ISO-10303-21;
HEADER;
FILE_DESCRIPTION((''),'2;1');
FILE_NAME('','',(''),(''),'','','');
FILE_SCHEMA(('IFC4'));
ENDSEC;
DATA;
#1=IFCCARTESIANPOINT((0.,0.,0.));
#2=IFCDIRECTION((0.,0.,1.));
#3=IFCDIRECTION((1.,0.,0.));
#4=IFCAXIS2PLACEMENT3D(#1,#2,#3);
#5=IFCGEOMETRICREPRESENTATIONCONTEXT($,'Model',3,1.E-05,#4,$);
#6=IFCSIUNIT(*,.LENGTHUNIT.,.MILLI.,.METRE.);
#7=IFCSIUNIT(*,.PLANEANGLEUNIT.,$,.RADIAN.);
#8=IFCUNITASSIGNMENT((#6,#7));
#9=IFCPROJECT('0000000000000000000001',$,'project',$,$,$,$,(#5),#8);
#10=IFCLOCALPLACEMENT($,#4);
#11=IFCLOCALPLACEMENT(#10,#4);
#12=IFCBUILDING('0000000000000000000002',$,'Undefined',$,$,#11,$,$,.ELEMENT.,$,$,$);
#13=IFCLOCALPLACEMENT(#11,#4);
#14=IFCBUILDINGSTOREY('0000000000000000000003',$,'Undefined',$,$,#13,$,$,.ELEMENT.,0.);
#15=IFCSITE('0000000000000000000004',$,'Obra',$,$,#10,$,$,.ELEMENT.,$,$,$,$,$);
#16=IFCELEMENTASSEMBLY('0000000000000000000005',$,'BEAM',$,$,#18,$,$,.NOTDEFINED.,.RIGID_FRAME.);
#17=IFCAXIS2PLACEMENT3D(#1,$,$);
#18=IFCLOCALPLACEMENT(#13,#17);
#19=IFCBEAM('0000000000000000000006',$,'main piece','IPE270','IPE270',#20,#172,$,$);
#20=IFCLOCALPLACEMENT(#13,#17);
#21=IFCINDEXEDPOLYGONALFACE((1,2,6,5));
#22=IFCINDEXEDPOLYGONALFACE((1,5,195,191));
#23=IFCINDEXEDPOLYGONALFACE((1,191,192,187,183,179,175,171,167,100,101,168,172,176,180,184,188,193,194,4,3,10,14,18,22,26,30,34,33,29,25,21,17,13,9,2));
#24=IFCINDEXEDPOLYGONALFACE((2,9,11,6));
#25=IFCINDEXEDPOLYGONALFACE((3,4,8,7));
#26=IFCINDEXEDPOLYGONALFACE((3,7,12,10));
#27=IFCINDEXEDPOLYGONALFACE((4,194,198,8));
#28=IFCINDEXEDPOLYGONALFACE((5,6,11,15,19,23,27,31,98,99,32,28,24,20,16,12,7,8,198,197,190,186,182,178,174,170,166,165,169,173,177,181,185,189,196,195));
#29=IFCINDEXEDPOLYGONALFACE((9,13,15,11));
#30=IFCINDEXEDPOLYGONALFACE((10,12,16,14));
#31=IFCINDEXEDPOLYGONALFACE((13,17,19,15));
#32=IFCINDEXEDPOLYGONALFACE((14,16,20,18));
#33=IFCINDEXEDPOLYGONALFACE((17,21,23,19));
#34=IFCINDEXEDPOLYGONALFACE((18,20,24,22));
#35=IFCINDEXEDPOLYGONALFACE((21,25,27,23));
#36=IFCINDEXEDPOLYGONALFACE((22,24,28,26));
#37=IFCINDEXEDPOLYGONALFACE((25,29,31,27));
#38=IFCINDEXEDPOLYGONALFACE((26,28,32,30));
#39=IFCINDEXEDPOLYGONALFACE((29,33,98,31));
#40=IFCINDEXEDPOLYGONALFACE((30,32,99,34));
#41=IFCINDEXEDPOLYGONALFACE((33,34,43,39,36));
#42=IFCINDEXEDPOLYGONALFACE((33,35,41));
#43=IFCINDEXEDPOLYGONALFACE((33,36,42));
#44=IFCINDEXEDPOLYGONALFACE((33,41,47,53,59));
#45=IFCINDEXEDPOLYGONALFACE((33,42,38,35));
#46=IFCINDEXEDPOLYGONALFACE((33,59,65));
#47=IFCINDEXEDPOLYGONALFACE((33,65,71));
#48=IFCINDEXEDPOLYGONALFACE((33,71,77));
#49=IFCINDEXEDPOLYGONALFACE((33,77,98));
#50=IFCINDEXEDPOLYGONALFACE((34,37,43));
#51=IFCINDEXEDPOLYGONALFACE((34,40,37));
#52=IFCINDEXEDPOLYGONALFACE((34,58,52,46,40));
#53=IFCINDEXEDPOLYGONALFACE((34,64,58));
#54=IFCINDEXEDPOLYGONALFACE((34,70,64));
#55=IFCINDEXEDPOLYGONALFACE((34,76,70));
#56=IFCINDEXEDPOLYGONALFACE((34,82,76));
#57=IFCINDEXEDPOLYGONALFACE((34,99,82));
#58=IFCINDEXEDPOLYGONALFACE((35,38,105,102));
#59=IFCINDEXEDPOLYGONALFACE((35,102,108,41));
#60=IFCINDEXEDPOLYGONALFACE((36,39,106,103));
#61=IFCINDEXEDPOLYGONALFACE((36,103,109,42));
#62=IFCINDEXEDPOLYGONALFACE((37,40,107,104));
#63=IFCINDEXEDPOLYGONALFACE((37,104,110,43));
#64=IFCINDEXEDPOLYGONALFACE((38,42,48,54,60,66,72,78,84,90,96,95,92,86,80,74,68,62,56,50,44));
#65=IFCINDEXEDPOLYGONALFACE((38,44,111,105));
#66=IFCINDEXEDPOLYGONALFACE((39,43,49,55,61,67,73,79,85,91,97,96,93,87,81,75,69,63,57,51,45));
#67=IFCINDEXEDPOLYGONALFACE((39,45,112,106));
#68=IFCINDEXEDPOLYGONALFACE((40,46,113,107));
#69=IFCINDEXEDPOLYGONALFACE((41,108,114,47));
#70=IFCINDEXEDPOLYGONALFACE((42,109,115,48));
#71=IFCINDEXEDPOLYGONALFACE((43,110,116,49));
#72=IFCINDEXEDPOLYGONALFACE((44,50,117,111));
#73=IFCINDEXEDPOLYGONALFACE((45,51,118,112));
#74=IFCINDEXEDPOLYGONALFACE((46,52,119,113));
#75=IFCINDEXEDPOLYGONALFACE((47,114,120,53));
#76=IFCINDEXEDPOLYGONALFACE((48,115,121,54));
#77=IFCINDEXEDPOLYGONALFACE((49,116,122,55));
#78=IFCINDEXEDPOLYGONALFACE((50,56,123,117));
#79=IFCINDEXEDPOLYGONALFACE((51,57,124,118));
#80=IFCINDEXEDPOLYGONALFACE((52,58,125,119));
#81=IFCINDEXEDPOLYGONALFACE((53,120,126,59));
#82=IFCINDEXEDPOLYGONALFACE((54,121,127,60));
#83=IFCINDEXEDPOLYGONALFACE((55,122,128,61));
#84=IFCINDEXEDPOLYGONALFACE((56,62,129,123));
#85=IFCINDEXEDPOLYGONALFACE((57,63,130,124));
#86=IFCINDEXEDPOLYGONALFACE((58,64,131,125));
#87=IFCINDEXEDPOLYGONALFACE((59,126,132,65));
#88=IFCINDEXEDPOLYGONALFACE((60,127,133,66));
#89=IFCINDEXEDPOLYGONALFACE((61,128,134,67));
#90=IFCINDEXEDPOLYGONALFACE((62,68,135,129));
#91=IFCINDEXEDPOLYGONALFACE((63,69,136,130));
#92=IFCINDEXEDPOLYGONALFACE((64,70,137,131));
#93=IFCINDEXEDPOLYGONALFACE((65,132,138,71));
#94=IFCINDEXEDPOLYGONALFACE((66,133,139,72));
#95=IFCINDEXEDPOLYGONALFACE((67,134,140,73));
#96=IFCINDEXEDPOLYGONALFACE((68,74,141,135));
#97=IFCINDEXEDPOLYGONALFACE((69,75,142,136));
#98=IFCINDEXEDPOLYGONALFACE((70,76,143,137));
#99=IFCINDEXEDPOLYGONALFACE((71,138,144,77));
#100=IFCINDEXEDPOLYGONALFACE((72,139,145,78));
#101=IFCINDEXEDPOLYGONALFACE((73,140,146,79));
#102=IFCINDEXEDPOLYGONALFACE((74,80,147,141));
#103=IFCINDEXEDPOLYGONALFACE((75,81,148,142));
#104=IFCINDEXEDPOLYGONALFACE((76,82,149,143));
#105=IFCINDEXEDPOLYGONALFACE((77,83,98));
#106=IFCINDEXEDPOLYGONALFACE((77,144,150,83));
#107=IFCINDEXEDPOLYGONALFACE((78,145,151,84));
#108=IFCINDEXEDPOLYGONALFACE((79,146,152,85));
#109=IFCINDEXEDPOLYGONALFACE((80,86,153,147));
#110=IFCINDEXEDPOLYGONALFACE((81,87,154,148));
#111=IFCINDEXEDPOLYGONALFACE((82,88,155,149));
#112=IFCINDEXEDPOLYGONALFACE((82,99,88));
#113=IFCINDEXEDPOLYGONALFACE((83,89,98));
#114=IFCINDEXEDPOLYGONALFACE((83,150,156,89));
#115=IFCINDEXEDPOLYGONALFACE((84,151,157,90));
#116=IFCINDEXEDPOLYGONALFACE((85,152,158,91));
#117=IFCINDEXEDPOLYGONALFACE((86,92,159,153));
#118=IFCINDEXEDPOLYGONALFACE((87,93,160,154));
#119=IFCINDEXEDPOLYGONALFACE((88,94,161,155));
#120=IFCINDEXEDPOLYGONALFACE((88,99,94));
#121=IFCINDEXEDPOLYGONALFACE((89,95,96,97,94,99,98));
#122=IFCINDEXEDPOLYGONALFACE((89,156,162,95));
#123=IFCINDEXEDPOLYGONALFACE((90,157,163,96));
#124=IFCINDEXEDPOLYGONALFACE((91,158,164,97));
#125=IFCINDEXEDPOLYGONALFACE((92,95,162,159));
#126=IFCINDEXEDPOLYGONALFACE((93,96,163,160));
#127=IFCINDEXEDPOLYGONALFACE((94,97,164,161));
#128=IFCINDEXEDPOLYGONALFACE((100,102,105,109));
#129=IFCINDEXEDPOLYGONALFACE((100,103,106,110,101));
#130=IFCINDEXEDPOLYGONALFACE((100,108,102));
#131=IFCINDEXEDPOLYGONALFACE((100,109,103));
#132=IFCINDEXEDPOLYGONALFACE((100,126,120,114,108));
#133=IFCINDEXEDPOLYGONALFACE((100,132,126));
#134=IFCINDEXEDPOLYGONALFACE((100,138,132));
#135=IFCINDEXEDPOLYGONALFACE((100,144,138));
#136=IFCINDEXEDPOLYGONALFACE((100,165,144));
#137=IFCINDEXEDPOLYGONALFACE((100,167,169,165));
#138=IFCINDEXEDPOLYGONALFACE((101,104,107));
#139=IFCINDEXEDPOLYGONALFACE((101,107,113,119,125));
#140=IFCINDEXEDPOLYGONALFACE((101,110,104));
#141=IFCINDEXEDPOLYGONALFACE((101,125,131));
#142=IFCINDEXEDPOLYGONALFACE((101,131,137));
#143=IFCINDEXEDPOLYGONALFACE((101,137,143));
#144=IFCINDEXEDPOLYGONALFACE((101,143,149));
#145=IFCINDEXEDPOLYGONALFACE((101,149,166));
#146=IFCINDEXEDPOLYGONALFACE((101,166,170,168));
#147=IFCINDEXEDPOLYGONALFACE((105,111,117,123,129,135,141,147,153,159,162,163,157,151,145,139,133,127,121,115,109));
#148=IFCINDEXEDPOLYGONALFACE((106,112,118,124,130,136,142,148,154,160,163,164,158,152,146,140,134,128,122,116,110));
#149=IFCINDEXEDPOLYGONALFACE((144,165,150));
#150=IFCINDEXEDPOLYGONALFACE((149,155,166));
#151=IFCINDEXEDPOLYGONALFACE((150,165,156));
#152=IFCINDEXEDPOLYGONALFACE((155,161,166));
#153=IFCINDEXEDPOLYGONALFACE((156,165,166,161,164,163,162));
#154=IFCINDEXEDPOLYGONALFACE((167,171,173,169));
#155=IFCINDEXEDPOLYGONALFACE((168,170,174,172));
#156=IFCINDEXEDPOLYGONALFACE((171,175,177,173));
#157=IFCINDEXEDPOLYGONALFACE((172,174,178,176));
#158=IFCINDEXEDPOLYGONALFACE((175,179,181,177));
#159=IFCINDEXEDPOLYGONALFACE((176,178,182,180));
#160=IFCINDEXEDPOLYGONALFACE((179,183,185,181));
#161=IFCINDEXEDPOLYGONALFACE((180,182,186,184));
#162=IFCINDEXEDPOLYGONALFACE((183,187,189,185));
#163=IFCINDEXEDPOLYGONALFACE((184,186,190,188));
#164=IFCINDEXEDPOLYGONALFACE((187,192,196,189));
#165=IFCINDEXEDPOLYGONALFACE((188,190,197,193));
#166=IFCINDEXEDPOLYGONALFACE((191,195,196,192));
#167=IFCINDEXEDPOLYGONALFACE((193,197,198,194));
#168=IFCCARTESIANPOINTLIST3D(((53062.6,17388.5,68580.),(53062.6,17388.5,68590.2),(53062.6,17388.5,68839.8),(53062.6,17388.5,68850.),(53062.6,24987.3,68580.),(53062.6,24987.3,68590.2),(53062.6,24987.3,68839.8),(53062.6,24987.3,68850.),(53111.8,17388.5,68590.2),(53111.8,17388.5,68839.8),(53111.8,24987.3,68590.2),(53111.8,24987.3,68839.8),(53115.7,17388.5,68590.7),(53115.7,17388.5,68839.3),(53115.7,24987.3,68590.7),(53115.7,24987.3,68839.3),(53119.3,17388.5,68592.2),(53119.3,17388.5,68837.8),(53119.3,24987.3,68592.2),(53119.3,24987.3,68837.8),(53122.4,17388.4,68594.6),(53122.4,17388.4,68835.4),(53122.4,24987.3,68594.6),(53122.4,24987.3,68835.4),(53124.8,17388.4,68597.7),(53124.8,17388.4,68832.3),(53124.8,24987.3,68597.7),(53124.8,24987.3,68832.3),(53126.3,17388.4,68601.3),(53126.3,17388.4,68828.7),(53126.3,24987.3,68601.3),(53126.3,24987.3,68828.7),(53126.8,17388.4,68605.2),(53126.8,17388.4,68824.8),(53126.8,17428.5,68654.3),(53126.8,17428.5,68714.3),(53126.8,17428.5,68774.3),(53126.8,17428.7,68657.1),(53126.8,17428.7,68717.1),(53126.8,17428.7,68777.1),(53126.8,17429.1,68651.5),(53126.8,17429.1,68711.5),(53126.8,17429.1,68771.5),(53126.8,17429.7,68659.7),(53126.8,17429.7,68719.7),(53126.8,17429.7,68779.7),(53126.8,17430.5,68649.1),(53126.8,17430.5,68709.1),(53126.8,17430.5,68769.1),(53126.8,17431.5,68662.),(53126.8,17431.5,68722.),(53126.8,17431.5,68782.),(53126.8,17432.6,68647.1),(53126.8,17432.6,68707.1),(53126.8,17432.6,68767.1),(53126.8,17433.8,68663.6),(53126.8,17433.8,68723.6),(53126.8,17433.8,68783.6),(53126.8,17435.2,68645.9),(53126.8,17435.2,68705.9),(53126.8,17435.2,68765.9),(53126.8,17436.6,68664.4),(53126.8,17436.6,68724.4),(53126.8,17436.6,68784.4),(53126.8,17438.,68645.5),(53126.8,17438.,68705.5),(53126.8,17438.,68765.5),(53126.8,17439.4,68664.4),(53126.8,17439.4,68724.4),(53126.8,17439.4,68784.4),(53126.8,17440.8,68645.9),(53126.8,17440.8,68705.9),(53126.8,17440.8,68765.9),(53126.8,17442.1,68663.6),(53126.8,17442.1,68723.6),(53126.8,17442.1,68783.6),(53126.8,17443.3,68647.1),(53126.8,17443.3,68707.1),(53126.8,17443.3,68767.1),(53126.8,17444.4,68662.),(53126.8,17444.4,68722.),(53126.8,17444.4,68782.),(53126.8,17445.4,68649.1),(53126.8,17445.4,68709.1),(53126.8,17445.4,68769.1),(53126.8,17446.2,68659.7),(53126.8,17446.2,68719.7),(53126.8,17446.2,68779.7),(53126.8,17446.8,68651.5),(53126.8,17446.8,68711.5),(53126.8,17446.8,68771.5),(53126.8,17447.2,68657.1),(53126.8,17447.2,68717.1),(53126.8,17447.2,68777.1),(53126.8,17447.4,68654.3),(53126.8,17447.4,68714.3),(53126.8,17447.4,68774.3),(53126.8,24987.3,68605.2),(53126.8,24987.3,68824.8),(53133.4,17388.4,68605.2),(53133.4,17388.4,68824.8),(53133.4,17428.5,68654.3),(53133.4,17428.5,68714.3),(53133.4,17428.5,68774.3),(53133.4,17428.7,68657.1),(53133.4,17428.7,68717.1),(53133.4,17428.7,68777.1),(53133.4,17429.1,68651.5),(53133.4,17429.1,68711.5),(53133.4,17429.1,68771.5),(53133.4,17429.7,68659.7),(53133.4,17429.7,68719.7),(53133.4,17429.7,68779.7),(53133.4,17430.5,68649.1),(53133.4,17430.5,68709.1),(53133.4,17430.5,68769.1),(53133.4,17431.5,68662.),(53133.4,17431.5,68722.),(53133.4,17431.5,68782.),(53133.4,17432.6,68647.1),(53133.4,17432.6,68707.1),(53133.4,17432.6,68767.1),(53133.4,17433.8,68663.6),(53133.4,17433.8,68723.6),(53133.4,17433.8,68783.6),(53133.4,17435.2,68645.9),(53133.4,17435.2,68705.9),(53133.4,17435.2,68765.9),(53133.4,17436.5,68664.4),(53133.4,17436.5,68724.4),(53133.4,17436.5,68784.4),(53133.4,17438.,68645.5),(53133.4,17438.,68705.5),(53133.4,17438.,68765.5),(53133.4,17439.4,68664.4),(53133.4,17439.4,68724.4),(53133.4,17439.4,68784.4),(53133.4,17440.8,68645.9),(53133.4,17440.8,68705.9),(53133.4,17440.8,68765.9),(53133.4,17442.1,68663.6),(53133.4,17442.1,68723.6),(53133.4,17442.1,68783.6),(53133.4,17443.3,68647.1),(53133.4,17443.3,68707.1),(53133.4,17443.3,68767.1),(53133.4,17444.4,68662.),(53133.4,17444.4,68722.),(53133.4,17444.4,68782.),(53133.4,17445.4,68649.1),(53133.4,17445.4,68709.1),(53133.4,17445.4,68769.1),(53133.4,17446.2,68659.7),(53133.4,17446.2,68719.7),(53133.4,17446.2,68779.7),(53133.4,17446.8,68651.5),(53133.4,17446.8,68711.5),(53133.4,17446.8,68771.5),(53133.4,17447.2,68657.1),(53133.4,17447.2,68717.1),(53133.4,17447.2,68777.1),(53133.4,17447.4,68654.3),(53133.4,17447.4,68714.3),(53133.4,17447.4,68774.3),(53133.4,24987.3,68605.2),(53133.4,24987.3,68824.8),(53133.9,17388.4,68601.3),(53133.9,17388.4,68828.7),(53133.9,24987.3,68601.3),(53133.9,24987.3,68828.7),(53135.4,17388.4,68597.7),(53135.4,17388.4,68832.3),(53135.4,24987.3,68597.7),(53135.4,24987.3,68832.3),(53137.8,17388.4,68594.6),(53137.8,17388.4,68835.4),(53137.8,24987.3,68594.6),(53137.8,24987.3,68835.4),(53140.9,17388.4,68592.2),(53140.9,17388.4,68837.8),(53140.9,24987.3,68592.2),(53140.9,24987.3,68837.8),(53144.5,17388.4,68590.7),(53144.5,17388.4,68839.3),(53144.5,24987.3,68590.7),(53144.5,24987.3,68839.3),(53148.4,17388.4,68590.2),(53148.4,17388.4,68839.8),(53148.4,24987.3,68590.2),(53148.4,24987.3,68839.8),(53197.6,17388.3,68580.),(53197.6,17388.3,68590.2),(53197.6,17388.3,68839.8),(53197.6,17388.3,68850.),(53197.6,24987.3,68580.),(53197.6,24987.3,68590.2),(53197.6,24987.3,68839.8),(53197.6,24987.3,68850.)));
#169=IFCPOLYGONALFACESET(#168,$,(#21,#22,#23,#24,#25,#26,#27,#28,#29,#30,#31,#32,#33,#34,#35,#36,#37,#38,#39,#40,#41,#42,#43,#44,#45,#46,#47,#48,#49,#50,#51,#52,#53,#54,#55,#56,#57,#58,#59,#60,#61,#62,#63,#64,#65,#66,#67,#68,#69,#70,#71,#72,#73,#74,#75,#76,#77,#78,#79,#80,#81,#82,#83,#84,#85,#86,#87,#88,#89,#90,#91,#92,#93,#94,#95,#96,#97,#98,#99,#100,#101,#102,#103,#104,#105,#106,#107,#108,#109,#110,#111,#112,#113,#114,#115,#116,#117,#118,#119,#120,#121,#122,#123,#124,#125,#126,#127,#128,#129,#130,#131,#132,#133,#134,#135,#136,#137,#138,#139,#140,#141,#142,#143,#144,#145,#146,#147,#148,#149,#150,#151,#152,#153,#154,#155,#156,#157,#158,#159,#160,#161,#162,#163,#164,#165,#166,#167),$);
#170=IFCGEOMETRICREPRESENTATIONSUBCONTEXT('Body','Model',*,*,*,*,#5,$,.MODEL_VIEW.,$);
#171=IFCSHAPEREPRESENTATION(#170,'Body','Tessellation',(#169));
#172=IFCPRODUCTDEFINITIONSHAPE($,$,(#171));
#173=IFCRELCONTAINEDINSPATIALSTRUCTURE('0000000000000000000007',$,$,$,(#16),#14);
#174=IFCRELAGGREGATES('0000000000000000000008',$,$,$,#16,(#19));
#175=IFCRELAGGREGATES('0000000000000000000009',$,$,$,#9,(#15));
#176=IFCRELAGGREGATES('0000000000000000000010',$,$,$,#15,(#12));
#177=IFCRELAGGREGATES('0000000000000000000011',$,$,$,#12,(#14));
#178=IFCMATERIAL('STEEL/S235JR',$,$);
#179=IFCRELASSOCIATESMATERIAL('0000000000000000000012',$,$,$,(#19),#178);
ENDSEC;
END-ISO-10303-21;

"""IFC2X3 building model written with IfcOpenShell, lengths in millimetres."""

from ifc_helpers import new_model, si_unit, frame, origin_with_axes, origin_2d_with_axis, place, context, subcontext, project, spatial, circle, i_section, extrude, clip, halfspace, source, transform, mapped, material, element, aggregate, save


model = new_model("IFC2X3")

# Units and contexts
model_context = context("Model", 3, precision=1e-05, world=origin_with_axes())
body_context = subcontext(model_context, "Body", "Model", "MODEL_VIEW")
ifc_project = project(units=[si_unit("LENGTHUNIT", "METRE", prefix="MILLI"), si_unit("PLANEANGLEUNIT", "RADIAN")], contexts=[model_context])

# Site, building, storey
site_placement = place(None, origin_with_axes())
site = spatial("IfcSite", under=ifc_project, at=site_placement, Name="Obra", CompositionType="ELEMENT")
building_placement = place(site_placement, origin_with_axes())
building = spatial("IfcBuilding", under=site, at=building_placement, Name="Undefined", CompositionType="ELEMENT")
storey_placement = place(building_placement, origin_with_axes())
storey = spatial("IfcBuildingStorey", under=building, at=storey_placement, Name="Undefined", CompositionType="ELEMENT", Elevation=0.0)

# Shared definitions
ifc_material_1 = material(Name="STEEL/S235JR")

# Element assembly, beam, opening
assembly_1_placement = place(storey_placement, origin_with_axes())
assembly_1 = element("IfcElementAssembly", 1, at=assembly_1_placement, inside=storey, Name="BEAM", AssemblyPlace="NOTDEFINED", PredefinedType="RIGID_FRAME")
beam_1_placement = place(assembly_1_placement, frame((53130.1, 17375.2, 68715.0), z_axis=(0.0, 0.0, 1.0), x_axis=(0.0, 1.0, 0.0)))
beam_1 = element("IfcBeam", 2, at=beam_1_placement, material=ifc_material_1, Name="main piece", Description="IPE270", ObjectType="IPE270", context=body_context, shape_type="Clipping", body=[
    clip(extrude(i_section(OverallWidth=135.0, OverallDepth=270.0, WebThickness=6.6, FlangeThickness=10.2, FilletRadius=15.0, at=origin_2d_with_axis()), frame((7612.1, 0.0, 0.0), z_axis=(-1.0, 0.0, 0.0), x_axis=(0.0, -1.0, 0.0)), (0.0, 0.0, 1.0), 7612.1), halfspace(frame((13.4, 59.2, -120.0), z_axis=(-0.999999, 0.00163, 0.0), x_axis=(0.0, 0.0, 1.0)), False)),
])
shared_shape_1 = source(origin_with_axes(), body_context, "Body", "SweptSolid", [
    extrude(circle(Radius=9.5, at=origin_2d_with_axis()), frame((0.0, -2.5, 0.0), z_axis=(0.0, 1.0, 0.0), x_axis=(1.0, 0.0, 0.0)), (0.0, 0.0, 1.0), 6.8),
])
opening_1_placement = place(assembly_1_placement, frame((53130.9, 17388.0, 68835.0), z_axis=(0.001649, 0.999999, 0.0), x_axis=(0.0, 0.0, -1.0)))
element("IfcOpeningElement", 3, at=opening_1_placement, cuts=beam_1, ObjectType="Opening", context=body_context, shape_type="MappedRepresentation", body=[
    mapped(shared_shape_1, transform((60.0, 0.0, 50.0))),
    mapped(shared_shape_1, transform((120.0, 0.0, 50.0))),
    mapped(shared_shape_1, transform((180.0, 0.0, 50.0))),
])
aggregate(assembly_1, [beam_1])

save(model, "model.ifc")
